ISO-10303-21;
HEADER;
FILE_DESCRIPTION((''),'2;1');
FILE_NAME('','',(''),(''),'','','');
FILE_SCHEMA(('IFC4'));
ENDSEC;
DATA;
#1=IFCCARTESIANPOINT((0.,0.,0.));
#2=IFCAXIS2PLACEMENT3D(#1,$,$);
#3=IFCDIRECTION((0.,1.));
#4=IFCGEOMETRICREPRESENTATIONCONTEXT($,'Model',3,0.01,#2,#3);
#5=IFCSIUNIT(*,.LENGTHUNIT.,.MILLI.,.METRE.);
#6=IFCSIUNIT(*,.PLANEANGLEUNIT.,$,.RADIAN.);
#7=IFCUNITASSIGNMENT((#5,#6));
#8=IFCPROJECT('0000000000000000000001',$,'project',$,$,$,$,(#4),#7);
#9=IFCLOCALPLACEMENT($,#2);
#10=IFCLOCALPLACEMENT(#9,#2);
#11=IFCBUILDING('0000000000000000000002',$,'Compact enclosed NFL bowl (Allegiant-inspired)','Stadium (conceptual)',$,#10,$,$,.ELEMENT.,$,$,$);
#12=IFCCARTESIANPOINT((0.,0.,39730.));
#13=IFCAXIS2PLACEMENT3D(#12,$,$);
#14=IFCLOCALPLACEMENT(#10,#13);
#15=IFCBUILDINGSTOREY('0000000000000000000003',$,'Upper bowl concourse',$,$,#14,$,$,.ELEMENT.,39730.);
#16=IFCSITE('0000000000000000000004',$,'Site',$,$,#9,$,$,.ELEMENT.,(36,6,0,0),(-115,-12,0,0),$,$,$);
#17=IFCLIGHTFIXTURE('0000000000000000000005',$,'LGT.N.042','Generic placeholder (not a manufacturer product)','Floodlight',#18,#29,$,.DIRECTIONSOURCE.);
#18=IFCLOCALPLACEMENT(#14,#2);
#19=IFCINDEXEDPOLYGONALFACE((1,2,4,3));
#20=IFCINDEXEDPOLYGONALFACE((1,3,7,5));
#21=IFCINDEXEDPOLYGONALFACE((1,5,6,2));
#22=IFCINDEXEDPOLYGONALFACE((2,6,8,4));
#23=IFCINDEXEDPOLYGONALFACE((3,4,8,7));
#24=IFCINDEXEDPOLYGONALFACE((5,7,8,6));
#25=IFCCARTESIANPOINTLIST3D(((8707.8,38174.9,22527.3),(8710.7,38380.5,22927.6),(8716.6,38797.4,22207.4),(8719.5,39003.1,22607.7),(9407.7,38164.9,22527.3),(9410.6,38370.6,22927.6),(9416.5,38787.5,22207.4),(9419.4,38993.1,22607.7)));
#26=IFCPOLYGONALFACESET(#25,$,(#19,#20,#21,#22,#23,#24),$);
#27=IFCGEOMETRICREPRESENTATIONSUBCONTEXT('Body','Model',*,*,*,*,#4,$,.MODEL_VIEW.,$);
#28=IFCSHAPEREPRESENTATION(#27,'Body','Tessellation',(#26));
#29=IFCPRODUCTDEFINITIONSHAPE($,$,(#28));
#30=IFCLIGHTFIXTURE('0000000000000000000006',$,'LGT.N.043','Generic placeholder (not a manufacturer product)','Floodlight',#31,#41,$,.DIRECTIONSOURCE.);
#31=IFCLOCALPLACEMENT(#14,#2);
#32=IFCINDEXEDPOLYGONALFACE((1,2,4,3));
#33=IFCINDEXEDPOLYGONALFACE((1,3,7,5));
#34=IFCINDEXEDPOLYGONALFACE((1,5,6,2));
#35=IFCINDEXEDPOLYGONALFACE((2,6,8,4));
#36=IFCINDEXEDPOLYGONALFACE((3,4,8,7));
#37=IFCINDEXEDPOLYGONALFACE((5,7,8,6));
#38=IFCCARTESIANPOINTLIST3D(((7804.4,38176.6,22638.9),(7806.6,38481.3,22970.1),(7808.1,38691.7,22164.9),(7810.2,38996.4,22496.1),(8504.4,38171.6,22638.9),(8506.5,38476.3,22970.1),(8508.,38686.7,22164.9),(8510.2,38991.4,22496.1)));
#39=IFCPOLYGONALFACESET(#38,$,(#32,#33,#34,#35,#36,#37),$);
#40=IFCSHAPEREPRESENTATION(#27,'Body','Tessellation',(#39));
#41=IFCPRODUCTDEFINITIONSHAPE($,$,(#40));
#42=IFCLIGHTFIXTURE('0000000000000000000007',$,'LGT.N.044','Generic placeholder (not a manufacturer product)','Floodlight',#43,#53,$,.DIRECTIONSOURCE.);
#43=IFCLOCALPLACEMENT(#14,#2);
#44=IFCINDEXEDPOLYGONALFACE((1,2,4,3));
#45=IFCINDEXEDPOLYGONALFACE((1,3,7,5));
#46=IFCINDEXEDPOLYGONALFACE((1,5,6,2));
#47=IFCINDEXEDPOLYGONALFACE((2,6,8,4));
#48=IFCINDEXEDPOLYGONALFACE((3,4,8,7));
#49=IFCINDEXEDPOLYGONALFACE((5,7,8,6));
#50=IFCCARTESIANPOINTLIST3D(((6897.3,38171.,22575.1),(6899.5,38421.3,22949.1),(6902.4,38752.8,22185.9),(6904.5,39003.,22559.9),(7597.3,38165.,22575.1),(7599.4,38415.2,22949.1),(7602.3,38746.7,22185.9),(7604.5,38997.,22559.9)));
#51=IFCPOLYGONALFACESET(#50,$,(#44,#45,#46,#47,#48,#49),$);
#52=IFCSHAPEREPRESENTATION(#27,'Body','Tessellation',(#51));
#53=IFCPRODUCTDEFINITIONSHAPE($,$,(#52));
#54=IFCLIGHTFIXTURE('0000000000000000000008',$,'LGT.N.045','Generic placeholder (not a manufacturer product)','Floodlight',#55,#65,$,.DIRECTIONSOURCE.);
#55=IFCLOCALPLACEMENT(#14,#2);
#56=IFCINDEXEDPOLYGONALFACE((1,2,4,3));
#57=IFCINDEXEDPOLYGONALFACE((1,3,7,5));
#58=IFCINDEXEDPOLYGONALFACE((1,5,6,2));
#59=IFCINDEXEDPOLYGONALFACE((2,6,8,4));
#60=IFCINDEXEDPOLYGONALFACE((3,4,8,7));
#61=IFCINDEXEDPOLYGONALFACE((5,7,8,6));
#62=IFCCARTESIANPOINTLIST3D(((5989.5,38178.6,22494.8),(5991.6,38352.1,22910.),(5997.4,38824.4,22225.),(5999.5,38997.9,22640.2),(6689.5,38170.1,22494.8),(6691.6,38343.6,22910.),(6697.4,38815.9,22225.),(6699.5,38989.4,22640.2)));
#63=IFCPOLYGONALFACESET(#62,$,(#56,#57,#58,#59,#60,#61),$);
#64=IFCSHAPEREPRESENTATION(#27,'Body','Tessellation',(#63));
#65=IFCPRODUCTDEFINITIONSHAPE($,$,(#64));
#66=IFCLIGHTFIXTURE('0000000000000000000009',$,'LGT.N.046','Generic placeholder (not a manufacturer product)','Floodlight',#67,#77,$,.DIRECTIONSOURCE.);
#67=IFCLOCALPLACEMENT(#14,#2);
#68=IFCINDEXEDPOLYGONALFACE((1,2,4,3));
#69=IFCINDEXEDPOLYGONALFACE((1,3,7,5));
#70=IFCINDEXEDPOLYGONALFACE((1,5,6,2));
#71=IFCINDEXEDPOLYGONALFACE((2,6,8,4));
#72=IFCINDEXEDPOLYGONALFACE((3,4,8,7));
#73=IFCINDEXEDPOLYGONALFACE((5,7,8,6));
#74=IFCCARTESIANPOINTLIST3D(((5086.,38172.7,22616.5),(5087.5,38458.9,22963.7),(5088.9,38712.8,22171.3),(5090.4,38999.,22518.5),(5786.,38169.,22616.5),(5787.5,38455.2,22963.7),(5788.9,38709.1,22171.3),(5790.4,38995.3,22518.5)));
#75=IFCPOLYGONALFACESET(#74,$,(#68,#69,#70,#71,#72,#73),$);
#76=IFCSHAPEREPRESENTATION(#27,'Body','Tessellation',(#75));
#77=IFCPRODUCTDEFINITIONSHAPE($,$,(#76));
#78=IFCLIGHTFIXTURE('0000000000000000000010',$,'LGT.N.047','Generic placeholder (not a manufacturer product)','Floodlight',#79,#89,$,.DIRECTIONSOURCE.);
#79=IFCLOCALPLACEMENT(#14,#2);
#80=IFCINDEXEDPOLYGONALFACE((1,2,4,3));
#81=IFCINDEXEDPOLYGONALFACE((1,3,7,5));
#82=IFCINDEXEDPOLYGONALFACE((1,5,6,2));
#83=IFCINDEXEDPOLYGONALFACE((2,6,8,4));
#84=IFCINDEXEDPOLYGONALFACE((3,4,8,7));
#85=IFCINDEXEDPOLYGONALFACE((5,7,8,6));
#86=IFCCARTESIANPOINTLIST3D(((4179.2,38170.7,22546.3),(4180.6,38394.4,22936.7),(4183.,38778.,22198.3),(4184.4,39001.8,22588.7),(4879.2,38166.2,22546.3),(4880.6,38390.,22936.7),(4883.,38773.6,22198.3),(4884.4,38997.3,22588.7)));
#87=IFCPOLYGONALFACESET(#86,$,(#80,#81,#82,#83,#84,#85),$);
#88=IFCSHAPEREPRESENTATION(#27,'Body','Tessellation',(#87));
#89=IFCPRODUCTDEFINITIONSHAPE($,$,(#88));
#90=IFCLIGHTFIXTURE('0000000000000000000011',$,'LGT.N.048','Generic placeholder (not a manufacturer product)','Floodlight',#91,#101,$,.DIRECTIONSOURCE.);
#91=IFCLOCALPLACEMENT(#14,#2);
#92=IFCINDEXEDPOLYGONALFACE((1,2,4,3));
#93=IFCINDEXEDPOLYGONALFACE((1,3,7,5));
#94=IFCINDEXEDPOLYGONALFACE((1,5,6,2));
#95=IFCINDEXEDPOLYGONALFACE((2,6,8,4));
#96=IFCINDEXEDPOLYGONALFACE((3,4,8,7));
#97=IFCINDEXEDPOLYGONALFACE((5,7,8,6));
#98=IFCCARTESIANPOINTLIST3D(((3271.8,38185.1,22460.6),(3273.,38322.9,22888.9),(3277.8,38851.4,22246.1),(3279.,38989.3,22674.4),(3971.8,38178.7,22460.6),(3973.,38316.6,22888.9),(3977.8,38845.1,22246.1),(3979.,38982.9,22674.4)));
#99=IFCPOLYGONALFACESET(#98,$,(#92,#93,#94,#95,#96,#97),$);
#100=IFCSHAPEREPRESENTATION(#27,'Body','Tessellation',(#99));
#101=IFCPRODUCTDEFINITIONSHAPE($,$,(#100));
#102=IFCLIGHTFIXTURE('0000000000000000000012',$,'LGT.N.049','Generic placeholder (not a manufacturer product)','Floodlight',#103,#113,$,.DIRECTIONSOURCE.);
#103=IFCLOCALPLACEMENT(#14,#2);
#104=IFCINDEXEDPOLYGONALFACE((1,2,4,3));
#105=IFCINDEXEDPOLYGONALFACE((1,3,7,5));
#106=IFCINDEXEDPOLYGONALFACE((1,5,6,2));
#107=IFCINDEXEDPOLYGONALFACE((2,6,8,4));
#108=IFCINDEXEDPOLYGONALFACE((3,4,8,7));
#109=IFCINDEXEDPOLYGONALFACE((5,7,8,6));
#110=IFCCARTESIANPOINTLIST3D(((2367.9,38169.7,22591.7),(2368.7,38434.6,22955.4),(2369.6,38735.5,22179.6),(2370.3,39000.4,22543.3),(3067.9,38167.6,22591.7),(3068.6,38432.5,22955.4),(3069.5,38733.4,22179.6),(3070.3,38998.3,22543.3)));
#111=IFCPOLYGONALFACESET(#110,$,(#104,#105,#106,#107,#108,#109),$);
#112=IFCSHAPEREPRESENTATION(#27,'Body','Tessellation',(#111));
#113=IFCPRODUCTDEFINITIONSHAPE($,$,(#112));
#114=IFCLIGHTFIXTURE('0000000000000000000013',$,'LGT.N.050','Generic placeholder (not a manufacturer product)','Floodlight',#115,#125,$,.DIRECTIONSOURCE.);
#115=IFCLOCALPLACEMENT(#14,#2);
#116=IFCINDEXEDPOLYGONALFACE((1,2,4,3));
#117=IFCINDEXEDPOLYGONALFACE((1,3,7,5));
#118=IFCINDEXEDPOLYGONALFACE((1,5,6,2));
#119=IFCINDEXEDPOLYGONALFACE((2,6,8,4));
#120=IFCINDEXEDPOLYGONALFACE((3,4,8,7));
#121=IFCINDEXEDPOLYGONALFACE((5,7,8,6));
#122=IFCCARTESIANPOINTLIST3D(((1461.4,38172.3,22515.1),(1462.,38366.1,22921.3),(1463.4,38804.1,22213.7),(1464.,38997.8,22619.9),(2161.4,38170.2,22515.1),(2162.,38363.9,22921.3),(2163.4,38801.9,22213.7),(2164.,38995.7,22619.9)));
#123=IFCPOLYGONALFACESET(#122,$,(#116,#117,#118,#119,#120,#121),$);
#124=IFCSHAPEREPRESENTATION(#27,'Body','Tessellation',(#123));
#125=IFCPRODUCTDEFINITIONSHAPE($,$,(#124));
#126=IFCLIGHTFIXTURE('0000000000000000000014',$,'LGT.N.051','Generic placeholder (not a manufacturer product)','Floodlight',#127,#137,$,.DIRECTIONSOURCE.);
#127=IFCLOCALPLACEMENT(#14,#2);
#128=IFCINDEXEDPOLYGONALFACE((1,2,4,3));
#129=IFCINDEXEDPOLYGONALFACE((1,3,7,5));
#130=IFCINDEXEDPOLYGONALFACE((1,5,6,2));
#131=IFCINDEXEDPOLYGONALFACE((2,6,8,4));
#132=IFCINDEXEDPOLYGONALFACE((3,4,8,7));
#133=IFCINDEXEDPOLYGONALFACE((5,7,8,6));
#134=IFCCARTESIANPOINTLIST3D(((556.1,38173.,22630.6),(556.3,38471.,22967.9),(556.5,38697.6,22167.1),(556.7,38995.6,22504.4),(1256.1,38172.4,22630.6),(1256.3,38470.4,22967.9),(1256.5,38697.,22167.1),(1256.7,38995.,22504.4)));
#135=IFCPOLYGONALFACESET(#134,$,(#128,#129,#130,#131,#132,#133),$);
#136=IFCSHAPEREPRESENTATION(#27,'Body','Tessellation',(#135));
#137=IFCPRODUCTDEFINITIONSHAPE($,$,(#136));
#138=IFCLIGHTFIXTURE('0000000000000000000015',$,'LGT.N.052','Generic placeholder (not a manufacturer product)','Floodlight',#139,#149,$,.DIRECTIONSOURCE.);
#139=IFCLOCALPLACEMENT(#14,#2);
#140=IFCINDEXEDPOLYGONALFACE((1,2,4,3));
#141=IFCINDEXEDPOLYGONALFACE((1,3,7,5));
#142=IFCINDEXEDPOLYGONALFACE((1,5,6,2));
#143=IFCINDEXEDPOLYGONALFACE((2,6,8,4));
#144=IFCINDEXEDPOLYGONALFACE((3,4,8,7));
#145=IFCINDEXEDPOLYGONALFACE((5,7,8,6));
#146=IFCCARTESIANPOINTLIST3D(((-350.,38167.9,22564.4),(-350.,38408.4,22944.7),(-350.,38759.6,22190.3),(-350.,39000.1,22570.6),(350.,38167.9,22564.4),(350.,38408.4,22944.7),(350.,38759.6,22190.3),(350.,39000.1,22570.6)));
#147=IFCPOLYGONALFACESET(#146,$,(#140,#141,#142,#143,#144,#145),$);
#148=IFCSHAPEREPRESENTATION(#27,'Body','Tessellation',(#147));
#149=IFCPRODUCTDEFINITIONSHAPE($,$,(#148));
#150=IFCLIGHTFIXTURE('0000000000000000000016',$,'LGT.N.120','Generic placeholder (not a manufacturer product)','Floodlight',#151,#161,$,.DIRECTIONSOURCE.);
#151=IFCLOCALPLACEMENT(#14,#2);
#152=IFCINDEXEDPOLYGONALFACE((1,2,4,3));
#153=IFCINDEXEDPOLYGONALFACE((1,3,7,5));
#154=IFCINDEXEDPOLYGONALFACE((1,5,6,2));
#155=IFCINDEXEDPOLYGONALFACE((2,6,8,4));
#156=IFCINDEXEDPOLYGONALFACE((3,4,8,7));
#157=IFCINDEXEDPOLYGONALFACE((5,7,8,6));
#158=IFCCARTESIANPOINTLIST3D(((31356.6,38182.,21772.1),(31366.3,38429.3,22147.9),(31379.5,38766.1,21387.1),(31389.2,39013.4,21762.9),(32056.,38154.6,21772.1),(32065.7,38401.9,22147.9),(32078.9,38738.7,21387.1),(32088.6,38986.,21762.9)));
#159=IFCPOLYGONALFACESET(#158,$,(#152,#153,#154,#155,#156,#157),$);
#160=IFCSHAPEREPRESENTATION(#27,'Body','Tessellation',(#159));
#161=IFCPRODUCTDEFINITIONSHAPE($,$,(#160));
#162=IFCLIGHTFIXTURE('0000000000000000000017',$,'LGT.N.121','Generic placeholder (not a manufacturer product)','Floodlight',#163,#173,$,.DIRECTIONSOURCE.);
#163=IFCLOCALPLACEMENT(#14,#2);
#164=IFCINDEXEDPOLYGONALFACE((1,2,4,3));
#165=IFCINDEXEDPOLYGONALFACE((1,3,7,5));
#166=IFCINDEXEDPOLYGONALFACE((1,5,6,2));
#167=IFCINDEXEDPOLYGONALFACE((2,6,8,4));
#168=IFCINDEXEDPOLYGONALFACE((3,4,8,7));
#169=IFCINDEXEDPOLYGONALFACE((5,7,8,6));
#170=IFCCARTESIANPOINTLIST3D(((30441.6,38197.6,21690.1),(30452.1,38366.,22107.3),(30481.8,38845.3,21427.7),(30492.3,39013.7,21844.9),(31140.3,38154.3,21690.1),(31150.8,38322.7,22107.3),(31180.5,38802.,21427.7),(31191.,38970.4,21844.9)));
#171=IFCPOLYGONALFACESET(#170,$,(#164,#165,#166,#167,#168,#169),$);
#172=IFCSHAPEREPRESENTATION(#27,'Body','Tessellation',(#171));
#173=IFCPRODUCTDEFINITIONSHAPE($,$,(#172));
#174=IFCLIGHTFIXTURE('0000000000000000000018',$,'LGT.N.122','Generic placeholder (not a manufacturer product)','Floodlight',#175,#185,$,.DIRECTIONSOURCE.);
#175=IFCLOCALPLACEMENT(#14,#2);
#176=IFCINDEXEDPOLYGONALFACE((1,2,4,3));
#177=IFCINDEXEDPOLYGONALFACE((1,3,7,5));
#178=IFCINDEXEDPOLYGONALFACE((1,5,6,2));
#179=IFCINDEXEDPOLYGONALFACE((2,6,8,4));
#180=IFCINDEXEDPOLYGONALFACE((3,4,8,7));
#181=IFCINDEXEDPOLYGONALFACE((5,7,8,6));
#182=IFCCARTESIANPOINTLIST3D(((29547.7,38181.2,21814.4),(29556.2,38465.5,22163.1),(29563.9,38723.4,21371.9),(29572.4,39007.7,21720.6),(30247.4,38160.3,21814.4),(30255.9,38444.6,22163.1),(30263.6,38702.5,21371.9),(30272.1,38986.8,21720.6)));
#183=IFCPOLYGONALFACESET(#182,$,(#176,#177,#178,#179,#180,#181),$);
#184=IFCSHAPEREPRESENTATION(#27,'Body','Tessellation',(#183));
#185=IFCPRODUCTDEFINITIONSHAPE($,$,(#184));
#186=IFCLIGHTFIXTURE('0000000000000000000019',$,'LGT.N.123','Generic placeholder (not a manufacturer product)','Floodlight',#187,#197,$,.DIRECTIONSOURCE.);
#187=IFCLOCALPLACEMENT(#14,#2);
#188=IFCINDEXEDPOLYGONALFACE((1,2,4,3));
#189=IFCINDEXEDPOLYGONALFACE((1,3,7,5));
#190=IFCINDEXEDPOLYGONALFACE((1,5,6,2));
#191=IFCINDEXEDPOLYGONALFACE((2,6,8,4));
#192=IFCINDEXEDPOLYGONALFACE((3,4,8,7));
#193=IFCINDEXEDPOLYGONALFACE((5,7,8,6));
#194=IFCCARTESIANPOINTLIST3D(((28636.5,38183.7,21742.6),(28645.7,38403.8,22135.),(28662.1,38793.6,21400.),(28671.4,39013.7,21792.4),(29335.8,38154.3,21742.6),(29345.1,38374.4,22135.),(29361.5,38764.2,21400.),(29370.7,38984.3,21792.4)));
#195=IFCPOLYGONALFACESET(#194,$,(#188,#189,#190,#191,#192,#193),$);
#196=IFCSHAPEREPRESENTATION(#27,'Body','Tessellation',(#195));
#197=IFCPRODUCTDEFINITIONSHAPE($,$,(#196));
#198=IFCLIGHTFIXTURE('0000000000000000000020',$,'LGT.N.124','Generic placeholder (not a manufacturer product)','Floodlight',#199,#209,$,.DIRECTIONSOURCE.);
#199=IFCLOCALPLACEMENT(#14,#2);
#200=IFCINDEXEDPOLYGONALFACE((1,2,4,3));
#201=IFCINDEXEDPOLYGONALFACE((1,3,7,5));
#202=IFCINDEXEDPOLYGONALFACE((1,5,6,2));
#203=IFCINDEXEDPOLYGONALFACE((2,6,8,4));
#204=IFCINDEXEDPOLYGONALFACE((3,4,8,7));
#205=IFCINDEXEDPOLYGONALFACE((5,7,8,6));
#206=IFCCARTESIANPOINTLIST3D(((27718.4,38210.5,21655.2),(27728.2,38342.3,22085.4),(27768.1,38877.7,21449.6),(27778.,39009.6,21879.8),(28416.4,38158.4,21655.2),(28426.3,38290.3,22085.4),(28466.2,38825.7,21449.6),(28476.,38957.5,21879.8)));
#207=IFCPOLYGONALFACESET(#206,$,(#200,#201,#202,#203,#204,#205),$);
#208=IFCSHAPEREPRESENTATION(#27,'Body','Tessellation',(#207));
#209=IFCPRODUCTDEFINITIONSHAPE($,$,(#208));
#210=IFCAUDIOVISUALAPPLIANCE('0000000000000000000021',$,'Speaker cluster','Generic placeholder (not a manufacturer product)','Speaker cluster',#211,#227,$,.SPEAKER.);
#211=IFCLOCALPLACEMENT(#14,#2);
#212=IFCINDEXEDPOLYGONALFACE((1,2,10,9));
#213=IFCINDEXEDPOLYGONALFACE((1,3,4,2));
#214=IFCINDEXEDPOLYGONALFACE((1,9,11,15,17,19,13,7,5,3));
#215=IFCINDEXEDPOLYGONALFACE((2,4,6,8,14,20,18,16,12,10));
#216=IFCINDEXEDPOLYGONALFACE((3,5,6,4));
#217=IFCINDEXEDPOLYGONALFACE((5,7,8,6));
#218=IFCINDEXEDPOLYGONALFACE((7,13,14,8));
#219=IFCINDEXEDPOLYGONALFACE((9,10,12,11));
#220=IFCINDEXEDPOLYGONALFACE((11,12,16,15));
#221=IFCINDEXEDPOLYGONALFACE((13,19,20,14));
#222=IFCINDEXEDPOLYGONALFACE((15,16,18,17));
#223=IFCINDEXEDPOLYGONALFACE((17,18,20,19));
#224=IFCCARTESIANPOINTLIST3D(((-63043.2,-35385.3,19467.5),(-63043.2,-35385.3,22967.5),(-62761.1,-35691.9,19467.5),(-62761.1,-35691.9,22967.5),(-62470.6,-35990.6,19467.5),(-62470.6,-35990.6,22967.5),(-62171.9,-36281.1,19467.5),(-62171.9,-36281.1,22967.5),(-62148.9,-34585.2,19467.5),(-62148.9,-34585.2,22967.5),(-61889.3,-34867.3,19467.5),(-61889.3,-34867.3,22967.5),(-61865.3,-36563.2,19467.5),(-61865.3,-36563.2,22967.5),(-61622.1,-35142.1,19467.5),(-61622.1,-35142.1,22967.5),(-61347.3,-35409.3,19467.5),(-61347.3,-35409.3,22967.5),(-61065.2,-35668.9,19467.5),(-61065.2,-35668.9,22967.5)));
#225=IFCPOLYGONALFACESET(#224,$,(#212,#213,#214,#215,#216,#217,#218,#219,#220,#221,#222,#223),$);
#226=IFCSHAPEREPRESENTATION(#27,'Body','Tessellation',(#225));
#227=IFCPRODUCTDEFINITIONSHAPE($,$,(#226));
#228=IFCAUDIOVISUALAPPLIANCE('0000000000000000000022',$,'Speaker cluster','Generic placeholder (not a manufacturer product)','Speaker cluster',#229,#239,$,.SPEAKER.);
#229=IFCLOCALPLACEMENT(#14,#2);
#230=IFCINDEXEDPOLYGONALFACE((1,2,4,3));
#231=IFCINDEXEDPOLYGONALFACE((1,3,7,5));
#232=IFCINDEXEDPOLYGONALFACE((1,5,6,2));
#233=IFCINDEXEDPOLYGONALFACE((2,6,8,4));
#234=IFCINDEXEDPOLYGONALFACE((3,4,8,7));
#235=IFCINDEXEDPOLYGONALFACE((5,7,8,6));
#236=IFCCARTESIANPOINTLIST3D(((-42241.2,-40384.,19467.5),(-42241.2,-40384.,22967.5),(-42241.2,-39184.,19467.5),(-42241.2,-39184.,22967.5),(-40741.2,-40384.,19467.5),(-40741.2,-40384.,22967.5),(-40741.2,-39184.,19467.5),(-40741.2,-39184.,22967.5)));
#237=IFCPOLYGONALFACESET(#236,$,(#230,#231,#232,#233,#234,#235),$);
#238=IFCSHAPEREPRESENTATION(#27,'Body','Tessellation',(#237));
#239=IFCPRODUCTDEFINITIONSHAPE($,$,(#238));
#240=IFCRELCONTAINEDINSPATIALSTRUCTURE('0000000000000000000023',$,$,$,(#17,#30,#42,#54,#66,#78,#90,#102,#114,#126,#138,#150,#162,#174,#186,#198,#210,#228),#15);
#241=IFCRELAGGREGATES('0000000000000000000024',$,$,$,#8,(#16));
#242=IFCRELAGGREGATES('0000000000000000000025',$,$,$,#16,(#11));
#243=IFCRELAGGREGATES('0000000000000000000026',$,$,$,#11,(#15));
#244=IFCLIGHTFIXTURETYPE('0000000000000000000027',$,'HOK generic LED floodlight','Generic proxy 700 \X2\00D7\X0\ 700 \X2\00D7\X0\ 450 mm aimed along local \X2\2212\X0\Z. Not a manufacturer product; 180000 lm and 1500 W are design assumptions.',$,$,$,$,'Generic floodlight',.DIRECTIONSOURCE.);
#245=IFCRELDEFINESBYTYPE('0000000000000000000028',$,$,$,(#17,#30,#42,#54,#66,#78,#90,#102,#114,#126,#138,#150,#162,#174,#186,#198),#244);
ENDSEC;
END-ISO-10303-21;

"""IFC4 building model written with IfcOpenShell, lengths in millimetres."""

from ifc_helpers import new_model, si_unit, direction, frame, origin, place, context, subcontext, project, spatial, line, arc, indexed_curve, rectangle, outline, extrude, source, transform, mapped, type_object, type_shapes, element, save


model = new_model("IFC4")

# Units and contexts
model_context = context("Model", 3, precision=0.01, world=origin(), true_north=direction((0.0, 1.0)))
body_context = subcontext(model_context, "Body", "Model", "MODEL_VIEW")
ifc_project = project(units=[si_unit("LENGTHUNIT", "METRE", prefix="MILLI"), si_unit("PLANEANGLEUNIT", "RADIAN")], contexts=[model_context])

# Site, building, storey
site_placement = place(None, origin())
site = spatial("IfcSite", under=ifc_project, at=site_placement, Name="Site", CompositionType="ELEMENT", RefLatitude=(36, 6, 0, 0), RefLongitude=(-115, -12, 0, 0))
building_placement = place(site_placement, origin())
building = spatial("IfcBuilding", under=site, at=building_placement, Name="Compact enclosed NFL bowl (Allegiant-inspired)", Description="Stadium (conceptual)", CompositionType="ELEMENT")
storey_placement = place(building_placement, frame((0.0, 0.0, 39730.0)))
storey = spatial("IfcBuildingStorey", under=building, at=storey_placement, Name="Upper bowl concourse", CompositionType="ELEMENT", Elevation=39730.0)

# Shared definitions
placement = place(storey_placement, frame((0.0, 0.0, -39730.0)))

# Light fixtures
light_fixture_type = type_object("IfcLightFixtureType", Name="HOK generic LED floodlight", Description="Generic proxy 700 × 700 × 450 mm aimed along local −Z. Not a manufacturer product; 180000 lm and 1500 W are design assumptions.", ElementType="Generic floodlight", PredefinedType="DIRECTIONSOURCE")
shared_shape = source(origin(), body_context, "Body", "SweptSolid", [
    extrude(rectangle(XDim=700.0, YDim=700.0), frame((0.0, 0.0, -225.0)), (0.0, 0.0, 1.0), 450.0),
])
type_shapes(light_fixture_type, [shared_shape])
for number, where, z_axis, x_axis, name in (
    (1, (9063.6, 38584.0, 22567.5), (0.00647, 0.456955, 0.889466), (-0.9999, 0.014158, 0.0), "LGT.N.042"),
    (2, (8157.3, 38584.0, 22567.5), (0.004818, 0.677106, 0.73587), (-0.999975, 0.007115, 0.0), "LGT.N.043"),
    (3, (7250.9, 38584.0, 22567.5), (0.004837, 0.55602, 0.831155), (-0.999962, 0.008699, 0.0), "LGT.N.044"),
    (4, (6344.5, 38584.0, 22567.5), (0.004698, 0.385503, 0.922694), (-0.999926, 0.012187, 0.0), "LGT.N.045"),
    (5, (5438.2, 38584.0, 22567.5), (0.003368, 0.636014, 0.77167), (-0.999986, 0.005296, 0.0), "LGT.N.046"),
    (6, (4531.8, 38584.0, 22567.5), (0.003156, 0.497186, 0.867638), (-0.99998, 0.006347, 0.0), "LGT.N.047"),
    (7, (3625.4, 38584.0, 22567.5), (0.00277, 0.306383, 0.951904), (-0.999959, 0.00904, 0.0), "LGT.N.048"),
    (8, (2719.1, 38584.0, 22567.5), (0.001764, 0.588696, 0.808353), (-0.999996, 0.002997, 0.0), "LGT.N.049"),
    (9, (1812.7, 38584.0, 22567.5), (0.001313, 0.430599, 0.902543), (-0.999995, 0.003049, 0.0), "LGT.N.050"),
    (10, (906.4, 38584.0, 22567.5), (0.000545, 0.662104, 0.749412), (-1.0, 0.000823, 0.0), "LGT.N.051"),
    (11, (0.0, 38584.0, 22567.5), (0.0, 0.534445, 0.845203), (-1.0, 0.0, 0.0), "LGT.N.052"),
    (12, (31722.6, 38584.0, 21767.5), (0.02154, 0.549597, 0.835152), (-0.999233, 0.039163, 0.0), "LGT.N.120"),
    (13, (30816.3, 38584.0, 21767.5), (0.023227, 0.374199, 0.927058), (-0.998079, 0.061953, 0.0), "LGT.N.121"),
    (14, (29909.9, 38584.0, 21767.5), (0.018844, 0.631801, 0.774902), (-0.999556, 0.029813, 0.0), "LGT.N.122"),
    (15, (29003.6, 38584.0, 21767.5), (0.020562, 0.489093, 0.871989), (-0.999117, 0.042005, 0.0), "LGT.N.123"),
    (16, (28097.2, 38584.0, 21767.5), (0.021836, 0.292935, 0.955883), (-0.997233, 0.074337, 0.0), "LGT.N.124"),
):
    element("IfcLightFixture", number, at=place(storey_placement, frame(where, z_axis=z_axis, x_axis=x_axis)), inside=storey, type_object=light_fixture_type, Name=name, Description="Generic placeholder (not a manufacturer product)", ObjectType="Floodlight", PredefinedType="DIRECTIONSOURCE", context=body_context, shape_type="MappedRepresentation", body=[
        mapped(shared_shape, transform((0.0, 0.0, 0.0))),
    ])

# Audio visual appliances
element("IfcAudioVisualAppliance", 17, at=placement, inside=storey, Name="Speaker cluster", Description="Generic placeholder (not a manufacturer product)", ObjectType="Speaker cluster", PredefinedType="SPEAKER", context=body_context, shape_type="SweptSolid", body=[
    extrude(outline(indexed_curve([(-62148.9, -34585.2), (-61622.1, -35142.1), (-61065.2, -35668.9), (-61865.3, -36563.2), (-62470.6, -35990.6), (-63043.2, -35385.3)], segments=[arc(1, 2, 3), line(3, 4), arc(4, 5, 6), line(6, 1)], self_intersect=False)), frame((0.0, 0.0, 59197.5)), (0.0, 0.0, 1.0), 3500.0),
])
element("IfcAudioVisualAppliance", 18, at=placement, inside=storey, Name="Speaker cluster", Description="Generic placeholder (not a manufacturer product)", ObjectType="Speaker cluster", PredefinedType="SPEAKER", context=body_context, shape_type="SweptSolid", body=[
    extrude(outline(indexed_curve([(-42241.2, -39184.0), (-40741.2, -39184.0), (-40741.2, -40384.0), (-42241.2, -40384.0)], segments=[line(1, 2), line(2, 3), line(3, 4), line(4, 1)], self_intersect=False)), frame((0.0, 0.0, 59197.5)), (0.0, 0.0, 1.0), 3500.0),
])

save(model, "model.ifc")
